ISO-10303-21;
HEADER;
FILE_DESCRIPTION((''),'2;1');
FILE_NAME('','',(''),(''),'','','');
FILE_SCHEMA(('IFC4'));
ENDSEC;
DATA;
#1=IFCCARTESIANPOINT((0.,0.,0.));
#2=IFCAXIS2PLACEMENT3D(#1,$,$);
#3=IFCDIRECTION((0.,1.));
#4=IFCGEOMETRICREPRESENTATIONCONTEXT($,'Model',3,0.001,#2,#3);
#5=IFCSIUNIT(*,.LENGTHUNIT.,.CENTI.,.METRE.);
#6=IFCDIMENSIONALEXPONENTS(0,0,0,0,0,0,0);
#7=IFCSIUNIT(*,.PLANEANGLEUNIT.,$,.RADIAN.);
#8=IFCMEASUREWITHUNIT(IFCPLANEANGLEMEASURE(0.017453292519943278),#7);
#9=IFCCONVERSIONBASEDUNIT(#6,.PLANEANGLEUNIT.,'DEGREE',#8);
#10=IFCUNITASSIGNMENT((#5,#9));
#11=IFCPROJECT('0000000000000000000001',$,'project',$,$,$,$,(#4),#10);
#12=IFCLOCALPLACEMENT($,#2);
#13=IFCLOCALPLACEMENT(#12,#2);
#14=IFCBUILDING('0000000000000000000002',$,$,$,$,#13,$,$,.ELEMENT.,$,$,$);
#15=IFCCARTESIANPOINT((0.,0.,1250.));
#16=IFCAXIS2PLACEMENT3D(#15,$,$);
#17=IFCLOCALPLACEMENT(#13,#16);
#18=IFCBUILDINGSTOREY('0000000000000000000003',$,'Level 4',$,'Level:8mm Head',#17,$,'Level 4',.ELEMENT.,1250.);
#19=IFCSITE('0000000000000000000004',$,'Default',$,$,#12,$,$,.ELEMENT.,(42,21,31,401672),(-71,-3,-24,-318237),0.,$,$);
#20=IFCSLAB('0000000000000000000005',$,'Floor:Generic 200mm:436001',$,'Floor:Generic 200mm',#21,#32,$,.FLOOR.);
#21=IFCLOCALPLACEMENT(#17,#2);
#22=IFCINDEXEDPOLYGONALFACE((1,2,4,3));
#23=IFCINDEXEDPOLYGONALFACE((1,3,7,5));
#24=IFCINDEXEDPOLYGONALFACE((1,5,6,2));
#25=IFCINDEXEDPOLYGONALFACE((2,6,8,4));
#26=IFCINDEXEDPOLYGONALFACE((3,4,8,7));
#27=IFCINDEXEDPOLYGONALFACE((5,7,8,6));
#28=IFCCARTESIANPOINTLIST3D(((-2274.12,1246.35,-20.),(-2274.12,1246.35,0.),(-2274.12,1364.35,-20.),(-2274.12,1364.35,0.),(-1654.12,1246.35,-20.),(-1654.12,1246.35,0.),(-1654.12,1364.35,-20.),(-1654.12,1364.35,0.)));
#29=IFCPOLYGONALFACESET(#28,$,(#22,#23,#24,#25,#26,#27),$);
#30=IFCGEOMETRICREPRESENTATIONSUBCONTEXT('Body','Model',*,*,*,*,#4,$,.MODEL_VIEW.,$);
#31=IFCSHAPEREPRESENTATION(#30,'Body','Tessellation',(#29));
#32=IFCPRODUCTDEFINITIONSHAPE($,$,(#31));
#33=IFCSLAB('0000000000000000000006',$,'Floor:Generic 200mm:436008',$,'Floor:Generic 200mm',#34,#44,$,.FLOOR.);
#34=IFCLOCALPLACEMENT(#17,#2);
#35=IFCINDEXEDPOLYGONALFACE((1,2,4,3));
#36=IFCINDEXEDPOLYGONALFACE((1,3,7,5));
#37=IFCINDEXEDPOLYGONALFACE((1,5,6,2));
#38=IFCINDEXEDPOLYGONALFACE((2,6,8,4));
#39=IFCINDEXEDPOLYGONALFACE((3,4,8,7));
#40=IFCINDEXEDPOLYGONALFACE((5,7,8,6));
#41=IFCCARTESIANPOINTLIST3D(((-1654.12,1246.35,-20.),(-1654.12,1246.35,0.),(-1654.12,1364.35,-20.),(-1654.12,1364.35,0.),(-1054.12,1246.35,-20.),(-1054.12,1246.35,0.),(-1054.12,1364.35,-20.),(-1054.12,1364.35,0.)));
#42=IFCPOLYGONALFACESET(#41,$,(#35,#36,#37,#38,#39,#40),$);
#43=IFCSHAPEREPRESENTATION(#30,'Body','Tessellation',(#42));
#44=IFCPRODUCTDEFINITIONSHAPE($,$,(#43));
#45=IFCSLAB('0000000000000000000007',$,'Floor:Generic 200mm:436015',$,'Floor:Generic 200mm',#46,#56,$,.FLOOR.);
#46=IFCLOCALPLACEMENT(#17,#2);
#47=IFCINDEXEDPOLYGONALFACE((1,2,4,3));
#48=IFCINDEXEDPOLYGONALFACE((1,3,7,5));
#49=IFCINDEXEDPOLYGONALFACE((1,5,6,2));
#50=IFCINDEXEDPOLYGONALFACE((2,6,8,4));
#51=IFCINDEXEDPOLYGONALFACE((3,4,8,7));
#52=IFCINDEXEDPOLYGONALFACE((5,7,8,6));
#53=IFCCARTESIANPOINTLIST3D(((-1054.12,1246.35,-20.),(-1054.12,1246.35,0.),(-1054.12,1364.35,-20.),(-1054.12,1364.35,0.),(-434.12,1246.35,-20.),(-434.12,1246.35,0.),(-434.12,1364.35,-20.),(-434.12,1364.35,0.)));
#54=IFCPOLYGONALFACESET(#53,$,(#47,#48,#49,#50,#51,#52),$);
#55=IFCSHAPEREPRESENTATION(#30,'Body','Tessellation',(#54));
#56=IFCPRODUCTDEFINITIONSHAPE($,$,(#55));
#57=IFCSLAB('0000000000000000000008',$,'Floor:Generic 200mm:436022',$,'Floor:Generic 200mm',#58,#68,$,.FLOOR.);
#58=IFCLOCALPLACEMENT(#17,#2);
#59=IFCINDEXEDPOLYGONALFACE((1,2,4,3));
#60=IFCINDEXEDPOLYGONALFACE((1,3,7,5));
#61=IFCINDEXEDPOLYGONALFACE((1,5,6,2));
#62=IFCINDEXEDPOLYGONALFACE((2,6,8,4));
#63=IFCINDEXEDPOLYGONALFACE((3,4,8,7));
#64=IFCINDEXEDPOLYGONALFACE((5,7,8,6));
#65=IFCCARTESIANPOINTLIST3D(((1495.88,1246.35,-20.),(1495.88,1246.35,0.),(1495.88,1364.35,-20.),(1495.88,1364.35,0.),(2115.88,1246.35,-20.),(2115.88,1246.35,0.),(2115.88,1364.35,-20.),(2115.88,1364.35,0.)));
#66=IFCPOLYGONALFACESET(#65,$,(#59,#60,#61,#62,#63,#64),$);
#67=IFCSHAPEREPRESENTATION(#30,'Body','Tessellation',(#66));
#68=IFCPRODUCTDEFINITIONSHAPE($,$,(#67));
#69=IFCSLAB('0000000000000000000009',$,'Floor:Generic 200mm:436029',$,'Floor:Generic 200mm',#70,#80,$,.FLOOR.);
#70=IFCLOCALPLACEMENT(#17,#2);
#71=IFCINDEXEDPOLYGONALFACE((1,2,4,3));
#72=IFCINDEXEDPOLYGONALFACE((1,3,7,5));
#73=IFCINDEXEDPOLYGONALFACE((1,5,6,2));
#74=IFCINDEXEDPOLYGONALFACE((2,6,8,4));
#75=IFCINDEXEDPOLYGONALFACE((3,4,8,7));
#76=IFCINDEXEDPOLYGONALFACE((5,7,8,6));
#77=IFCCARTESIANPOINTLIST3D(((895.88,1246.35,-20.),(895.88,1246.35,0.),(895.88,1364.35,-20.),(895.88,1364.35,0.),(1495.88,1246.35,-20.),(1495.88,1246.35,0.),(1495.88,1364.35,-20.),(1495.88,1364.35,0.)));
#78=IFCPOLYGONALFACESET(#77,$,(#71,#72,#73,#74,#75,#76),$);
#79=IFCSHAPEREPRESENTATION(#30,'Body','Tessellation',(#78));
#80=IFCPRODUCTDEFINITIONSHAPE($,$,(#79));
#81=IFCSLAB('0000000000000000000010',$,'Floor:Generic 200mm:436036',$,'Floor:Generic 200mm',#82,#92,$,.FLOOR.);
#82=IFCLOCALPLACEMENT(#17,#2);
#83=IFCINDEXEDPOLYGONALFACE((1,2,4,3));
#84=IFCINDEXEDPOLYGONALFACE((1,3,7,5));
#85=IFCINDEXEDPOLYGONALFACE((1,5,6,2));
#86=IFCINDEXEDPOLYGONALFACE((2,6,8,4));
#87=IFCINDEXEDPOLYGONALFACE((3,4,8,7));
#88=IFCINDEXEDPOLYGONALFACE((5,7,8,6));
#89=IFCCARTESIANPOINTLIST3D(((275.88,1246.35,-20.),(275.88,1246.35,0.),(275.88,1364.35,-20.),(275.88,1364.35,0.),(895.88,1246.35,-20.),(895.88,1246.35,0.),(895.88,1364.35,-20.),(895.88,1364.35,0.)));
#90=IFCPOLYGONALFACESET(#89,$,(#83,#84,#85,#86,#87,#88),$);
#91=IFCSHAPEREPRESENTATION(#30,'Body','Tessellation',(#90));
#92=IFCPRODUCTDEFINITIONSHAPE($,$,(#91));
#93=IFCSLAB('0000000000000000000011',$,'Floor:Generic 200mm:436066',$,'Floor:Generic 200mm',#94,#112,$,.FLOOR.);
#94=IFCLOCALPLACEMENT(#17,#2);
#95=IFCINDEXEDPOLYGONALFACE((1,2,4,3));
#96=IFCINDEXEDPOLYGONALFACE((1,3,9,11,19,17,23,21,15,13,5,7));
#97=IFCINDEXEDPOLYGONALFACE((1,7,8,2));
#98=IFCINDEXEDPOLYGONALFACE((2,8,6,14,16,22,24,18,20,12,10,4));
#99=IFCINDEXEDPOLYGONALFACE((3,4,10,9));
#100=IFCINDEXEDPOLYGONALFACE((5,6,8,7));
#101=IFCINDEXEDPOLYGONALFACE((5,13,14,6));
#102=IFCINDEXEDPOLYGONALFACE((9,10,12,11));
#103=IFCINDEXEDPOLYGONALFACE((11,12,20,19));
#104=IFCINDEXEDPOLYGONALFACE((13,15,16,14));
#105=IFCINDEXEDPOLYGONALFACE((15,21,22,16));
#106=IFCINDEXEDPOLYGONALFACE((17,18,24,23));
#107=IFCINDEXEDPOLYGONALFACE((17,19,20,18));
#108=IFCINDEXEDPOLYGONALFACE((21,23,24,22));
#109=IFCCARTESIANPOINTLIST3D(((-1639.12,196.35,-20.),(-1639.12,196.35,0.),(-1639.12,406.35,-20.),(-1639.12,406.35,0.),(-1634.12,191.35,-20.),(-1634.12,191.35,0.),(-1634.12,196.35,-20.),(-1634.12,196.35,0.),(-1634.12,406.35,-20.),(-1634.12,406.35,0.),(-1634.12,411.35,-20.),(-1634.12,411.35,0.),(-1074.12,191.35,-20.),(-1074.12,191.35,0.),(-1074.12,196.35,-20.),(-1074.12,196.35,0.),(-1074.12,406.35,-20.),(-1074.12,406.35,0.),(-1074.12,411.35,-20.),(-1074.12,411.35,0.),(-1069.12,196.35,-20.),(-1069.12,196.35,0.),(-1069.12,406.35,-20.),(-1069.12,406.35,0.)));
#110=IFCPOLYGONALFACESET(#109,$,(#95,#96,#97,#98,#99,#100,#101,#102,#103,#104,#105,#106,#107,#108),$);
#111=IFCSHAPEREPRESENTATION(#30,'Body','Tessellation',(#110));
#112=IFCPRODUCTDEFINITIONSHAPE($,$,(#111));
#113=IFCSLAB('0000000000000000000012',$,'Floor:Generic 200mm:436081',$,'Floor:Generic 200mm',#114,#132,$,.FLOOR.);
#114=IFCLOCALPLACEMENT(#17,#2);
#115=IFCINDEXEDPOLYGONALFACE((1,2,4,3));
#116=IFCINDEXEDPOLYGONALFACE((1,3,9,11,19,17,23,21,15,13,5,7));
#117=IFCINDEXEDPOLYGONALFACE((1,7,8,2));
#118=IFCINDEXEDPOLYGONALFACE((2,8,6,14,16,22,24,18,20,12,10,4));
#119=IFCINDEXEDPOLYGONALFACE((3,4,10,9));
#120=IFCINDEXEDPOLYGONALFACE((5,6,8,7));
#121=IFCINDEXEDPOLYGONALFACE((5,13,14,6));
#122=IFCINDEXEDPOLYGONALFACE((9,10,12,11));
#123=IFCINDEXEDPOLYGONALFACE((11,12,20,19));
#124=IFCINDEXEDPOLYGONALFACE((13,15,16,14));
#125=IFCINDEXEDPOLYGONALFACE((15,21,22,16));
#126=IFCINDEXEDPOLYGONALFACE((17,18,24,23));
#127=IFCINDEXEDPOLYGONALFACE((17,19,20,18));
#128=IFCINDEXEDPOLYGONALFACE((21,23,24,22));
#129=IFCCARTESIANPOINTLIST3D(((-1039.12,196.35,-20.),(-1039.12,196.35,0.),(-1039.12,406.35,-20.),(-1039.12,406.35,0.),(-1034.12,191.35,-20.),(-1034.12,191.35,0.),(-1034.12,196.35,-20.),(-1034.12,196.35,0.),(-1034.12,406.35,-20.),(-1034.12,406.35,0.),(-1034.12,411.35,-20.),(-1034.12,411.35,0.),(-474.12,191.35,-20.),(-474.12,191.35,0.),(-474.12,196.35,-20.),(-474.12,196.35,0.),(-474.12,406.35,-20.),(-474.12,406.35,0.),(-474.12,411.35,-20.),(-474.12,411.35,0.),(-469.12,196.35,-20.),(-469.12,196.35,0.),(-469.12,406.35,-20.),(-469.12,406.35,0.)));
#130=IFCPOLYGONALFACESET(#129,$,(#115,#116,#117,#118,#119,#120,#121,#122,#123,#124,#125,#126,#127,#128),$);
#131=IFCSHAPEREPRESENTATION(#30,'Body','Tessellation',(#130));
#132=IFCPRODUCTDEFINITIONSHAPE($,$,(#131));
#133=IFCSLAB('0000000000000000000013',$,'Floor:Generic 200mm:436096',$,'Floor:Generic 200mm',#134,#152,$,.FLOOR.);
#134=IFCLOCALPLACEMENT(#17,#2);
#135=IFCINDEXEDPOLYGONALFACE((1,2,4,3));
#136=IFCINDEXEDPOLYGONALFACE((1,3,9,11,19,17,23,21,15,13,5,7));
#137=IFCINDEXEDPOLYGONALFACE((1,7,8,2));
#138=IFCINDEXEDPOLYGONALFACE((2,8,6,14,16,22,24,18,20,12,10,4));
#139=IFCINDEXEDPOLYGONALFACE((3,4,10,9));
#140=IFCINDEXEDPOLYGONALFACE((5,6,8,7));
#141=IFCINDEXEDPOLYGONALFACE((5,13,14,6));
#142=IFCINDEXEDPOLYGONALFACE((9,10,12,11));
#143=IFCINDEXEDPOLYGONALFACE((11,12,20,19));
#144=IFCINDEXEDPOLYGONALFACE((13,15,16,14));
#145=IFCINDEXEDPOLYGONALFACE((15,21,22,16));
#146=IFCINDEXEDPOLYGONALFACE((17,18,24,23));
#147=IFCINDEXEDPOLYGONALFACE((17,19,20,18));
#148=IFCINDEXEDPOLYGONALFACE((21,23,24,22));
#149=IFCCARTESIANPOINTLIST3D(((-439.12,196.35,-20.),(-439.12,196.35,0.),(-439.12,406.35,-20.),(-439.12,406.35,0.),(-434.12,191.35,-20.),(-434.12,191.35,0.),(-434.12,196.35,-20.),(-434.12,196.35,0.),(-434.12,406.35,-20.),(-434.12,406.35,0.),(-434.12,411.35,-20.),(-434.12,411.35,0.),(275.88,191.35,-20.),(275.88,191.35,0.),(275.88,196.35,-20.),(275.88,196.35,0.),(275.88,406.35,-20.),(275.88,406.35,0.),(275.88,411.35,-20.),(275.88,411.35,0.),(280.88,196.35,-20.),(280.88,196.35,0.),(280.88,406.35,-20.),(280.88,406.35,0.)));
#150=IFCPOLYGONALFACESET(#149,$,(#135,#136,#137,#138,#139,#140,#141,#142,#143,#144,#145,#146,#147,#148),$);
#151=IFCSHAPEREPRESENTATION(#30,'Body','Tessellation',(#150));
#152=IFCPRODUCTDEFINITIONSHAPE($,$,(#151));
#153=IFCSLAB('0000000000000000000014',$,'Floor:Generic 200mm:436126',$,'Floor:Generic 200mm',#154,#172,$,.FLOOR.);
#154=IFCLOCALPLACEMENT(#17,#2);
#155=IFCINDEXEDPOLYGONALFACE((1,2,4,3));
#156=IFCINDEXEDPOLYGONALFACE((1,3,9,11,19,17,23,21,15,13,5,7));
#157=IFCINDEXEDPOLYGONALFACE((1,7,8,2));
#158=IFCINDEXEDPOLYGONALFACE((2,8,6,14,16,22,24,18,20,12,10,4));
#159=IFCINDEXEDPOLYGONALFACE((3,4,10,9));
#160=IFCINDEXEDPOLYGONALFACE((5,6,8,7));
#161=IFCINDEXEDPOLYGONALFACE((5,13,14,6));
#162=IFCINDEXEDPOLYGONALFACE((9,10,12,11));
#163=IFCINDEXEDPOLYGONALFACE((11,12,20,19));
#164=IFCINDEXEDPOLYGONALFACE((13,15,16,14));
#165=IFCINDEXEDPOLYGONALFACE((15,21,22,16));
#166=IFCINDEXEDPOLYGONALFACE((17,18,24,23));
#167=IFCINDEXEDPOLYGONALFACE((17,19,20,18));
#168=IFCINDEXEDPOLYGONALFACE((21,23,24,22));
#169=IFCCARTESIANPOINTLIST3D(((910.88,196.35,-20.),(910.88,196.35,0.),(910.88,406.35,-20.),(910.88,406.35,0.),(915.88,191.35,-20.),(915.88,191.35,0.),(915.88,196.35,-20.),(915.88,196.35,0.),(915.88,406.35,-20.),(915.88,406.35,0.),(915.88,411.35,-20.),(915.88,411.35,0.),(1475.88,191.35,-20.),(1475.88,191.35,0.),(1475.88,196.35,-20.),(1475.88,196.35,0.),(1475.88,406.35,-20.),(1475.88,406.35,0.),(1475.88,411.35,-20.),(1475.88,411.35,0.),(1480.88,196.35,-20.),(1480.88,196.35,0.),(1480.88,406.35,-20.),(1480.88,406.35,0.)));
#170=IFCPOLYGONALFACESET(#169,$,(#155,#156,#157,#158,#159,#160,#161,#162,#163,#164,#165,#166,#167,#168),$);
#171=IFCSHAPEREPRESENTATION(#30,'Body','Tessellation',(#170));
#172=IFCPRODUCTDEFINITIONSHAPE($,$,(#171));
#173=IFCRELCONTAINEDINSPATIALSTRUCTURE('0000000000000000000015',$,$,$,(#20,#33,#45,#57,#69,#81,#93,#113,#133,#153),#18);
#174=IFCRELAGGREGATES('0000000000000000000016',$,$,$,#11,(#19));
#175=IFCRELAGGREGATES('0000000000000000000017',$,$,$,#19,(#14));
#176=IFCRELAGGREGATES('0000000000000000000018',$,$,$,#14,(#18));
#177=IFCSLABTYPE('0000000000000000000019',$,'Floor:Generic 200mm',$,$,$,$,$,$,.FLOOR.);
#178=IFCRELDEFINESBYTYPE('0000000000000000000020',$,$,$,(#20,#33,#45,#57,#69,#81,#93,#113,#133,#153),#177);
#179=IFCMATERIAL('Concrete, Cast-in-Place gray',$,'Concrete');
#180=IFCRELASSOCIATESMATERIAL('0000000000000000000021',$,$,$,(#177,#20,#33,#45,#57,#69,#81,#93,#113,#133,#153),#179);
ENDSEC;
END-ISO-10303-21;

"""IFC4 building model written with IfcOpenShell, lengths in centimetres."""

from ifc_helpers import new_model, entity, si_unit, converted_unit, direction, frame, origin, place, context, subcontext, project, spatial, indexed_curve, outline, extrude, material, type_object, element, save


model = new_model("IFC4")

# Units and contexts
model_context = context("Model", 3, precision=0.001, world=origin(), true_north=direction((0.0, 1.0)))
body_context = subcontext(model_context, "Body", "Model", "MODEL_VIEW")
ifc_project = project(units=[si_unit("LENGTHUNIT", "METRE", prefix="CENTI"), converted_unit("PLANEANGLEUNIT", "DEGREE", entity("IfcPlaneAngleMeasure", 0.017453292519943278), si_unit("PLANEANGLEUNIT", "RADIAN"), dimensions=[0, 0, 0, 0, 0, 0, 0])], contexts=[model_context])

# Site, building, storey
site_placement = place(None, origin())
site = spatial("IfcSite", under=ifc_project, at=site_placement, Name="Default", CompositionType="ELEMENT", RefLatitude=(42, 21, 31, 401672), RefLongitude=(-71, -3, -24, -318237), RefElevation=0.0)
building_placement = place(site_placement, origin())
building = spatial("IfcBuilding", under=site, at=building_placement, CompositionType="ELEMENT")
storey_placement = place(building_placement, frame((0.0, 0.0, 1250.0)))
storey = spatial("IfcBuildingStorey", under=building, at=storey_placement, Name="Level 4", ObjectType="Level:8mm Head", LongName="Level 4", CompositionType="ELEMENT", Elevation=1250.0)

# Shared definitions
ifc_material = material(Name="Concrete, Cast-in-Place gray", Category="Concrete")
slab_type = type_object("IfcSlabType", Name="Floor:Generic 200mm", PredefinedType="FLOOR", material=ifc_material)

# Slabs
slab_1_placement = place(storey_placement, origin())
element("IfcSlab", 1, at=slab_1_placement, inside=storey, type_object=slab_type, material=ifc_material, Name="Floor:Generic 200mm:436001", ObjectType="Floor:Generic 200mm", PredefinedType="FLOOR", context=body_context, shape_type="SweptSolid", body=[
    extrude(outline(indexed_curve([(-59.0, -310.0), (59.0, -310.0), (59.0, 310.0), (-59.0, 310.0), (-59.0, -310.0)], self_intersect=False)), frame((-1964.12, 1305.35, 0.0), z_axis=(0.0, 0.0, -1.0), x_axis=(0.0, 1.0, 0.0)), (0.0, 0.0, 1.0), 20.0),
])
slab_2_placement = place(storey_placement, origin())
element("IfcSlab", 2, at=slab_2_placement, inside=storey, type_object=slab_type, material=ifc_material, Name="Floor:Generic 200mm:436008", ObjectType="Floor:Generic 200mm", PredefinedType="FLOOR", context=body_context, shape_type="SweptSolid", body=[
    extrude(outline(indexed_curve([(-59.0, -300.0), (59.0, -300.0), (59.0, 300.0), (-59.0, 300.0), (-59.0, -300.0)], self_intersect=False)), frame((-1354.12, 1305.35, 0.0), z_axis=(0.0, 0.0, -1.0), x_axis=(0.0, 1.0, 0.0)), (0.0, 0.0, 1.0), 20.0),
])
slab_3_placement = place(storey_placement, origin())
element("IfcSlab", 3, at=slab_3_placement, inside=storey, type_object=slab_type, material=ifc_material, Name="Floor:Generic 200mm:436015", ObjectType="Floor:Generic 200mm", PredefinedType="FLOOR", context=body_context, shape_type="SweptSolid", body=[
    extrude(outline(indexed_curve([(-59.0, -310.0), (59.0, -310.0), (59.0, 310.0), (-59.0, 310.0), (-59.0, -310.0)], self_intersect=False)), frame((-744.12, 1305.35, 0.0), z_axis=(0.0, 0.0, -1.0), x_axis=(0.0, 1.0, 0.0)), (0.0, 0.0, 1.0), 20.0),
])
slab_4_placement = place(storey_placement, origin())
element("IfcSlab", 4, at=slab_4_placement, inside=storey, type_object=slab_type, material=ifc_material, Name="Floor:Generic 200mm:436022", ObjectType="Floor:Generic 200mm", PredefinedType="FLOOR", context=body_context, shape_type="SweptSolid", body=[
    extrude(outline(indexed_curve([(-59.0, -310.0), (59.0, -310.0), (59.0, 310.0), (-59.0, 310.0), (-59.0, -310.0)], self_intersect=False)), frame((1805.88, 1305.35, 0.0), z_axis=(0.0, 0.0, -1.0), x_axis=(0.0, 1.0, 0.0)), (0.0, 0.0, 1.0), 20.0),
])
slab_5_placement = place(storey_placement, origin())
element("IfcSlab", 5, at=slab_5_placement, inside=storey, type_object=slab_type, material=ifc_material, Name="Floor:Generic 200mm:436029", ObjectType="Floor:Generic 200mm", PredefinedType="FLOOR", context=body_context, shape_type="SweptSolid", body=[
    extrude(outline(indexed_curve([(-59.0, -300.0), (59.0, -300.0), (59.0, 300.0), (-59.0, 300.0), (-59.0, -300.0)], self_intersect=False)), frame((1195.88, 1305.35, 0.0), z_axis=(0.0, 0.0, -1.0), x_axis=(0.0, 1.0, 0.0)), (0.0, 0.0, 1.0), 20.0),
])
slab_6_placement = place(storey_placement, origin())
element("IfcSlab", 6, at=slab_6_placement, inside=storey, type_object=slab_type, material=ifc_material, Name="Floor:Generic 200mm:436036", ObjectType="Floor:Generic 200mm", PredefinedType="FLOOR", context=body_context, shape_type="SweptSolid", body=[
    extrude(outline(indexed_curve([(-59.0, -310.0), (59.0, -310.0), (59.0, 310.0), (-59.0, 310.0), (-59.0, -310.0)], self_intersect=False)), frame((585.88, 1305.35, 0.0), z_axis=(0.0, 0.0, -1.0), x_axis=(0.0, 1.0, 0.0)), (0.0, 0.0, 1.0), 20.0),
])
slab_7_placement = place(storey_placement, origin())
element("IfcSlab", 7, at=slab_7_placement, inside=storey, type_object=slab_type, material=ifc_material, Name="Floor:Generic 200mm:436066", ObjectType="Floor:Generic 200mm", PredefinedType="FLOOR", context=body_context, shape_type="SweptSolid", body=[
    extrude(outline(indexed_curve([(-105.0, -285.0), (105.0, -285.0), (105.0, -280.0), (110.0, -280.0), (110.0, 280.0), (105.0, 280.0), (105.0, 285.0), (-105.0, 285.0), (-105.0, 280.0), (-110.0, 280.0), (-110.0, -280.0), (-105.0, -280.0), (-105.0, -285.0)], self_intersect=False)), frame((-1354.12, 301.35, 0.0), z_axis=(0.0, 0.0, -1.0), x_axis=(0.0, 1.0, 0.0)), (0.0, 0.0, 1.0), 20.0),
])
slab_8_placement = place(storey_placement, origin())
element("IfcSlab", 8, at=slab_8_placement, inside=storey, type_object=slab_type, material=ifc_material, Name="Floor:Generic 200mm:436081", ObjectType="Floor:Generic 200mm", PredefinedType="FLOOR", context=body_context, shape_type="SweptSolid", body=[
    extrude(outline(indexed_curve([(-105.0, -285.0), (105.0, -285.0), (105.0, -280.0), (110.0, -280.0), (110.0, 280.0), (105.0, 280.0), (105.0, 285.0), (-105.0, 285.0), (-105.0, 280.0), (-110.0, 280.0), (-110.0, -280.0), (-105.0, -280.0), (-105.0, -285.0)], self_intersect=False)), frame((-754.12, 301.35, 0.0), z_axis=(0.0, 0.0, -1.0), x_axis=(0.0, 1.0, 0.0)), (0.0, 0.0, 1.0), 20.0),
])
slab_9_placement = place(storey_placement, origin())
element("IfcSlab", 9, at=slab_9_placement, inside=storey, type_object=slab_type, material=ifc_material, Name="Floor:Generic 200mm:436096", ObjectType="Floor:Generic 200mm", PredefinedType="FLOOR", context=body_context, shape_type="SweptSolid", body=[
    extrude(outline(indexed_curve([(-105.0, -360.0), (105.0, -360.0), (105.0, -355.0), (110.0, -355.0), (110.0, 355.0), (105.0, 355.0), (105.0, 360.0), (-105.0, 360.0), (-105.0, 355.0), (-110.0, 355.0), (-110.0, -355.0), (-105.0, -355.0), (-105.0, -360.0)], self_intersect=False)), frame((-79.12, 301.35, 0.0), z_axis=(0.0, 0.0, -1.0), x_axis=(0.0, 1.0, 0.0)), (0.0, 0.0, 1.0), 20.0),
])
slab_10_placement = place(storey_placement, origin())
element("IfcSlab", 10, at=slab_10_placement, inside=storey, type_object=slab_type, material=ifc_material, Name="Floor:Generic 200mm:436126", ObjectType="Floor:Generic 200mm", PredefinedType="FLOOR", context=body_context, shape_type="SweptSolid", body=[
    extrude(outline(indexed_curve([(-105.0, -285.0), (105.0, -285.0), (105.0, -280.0), (110.0, -280.0), (110.0, 280.0), (105.0, 280.0), (105.0, 285.0), (-105.0, 285.0), (-105.0, 280.0), (-110.0, 280.0), (-110.0, -280.0), (-105.0, -280.0), (-105.0, -285.0)], self_intersect=False)), frame((1195.88, 301.35, 0.0), z_axis=(0.0, 0.0, -1.0), x_axis=(0.0, 1.0, 0.0)), (0.0, 0.0, 1.0), 20.0),
])

save(model, "model.ifc")
